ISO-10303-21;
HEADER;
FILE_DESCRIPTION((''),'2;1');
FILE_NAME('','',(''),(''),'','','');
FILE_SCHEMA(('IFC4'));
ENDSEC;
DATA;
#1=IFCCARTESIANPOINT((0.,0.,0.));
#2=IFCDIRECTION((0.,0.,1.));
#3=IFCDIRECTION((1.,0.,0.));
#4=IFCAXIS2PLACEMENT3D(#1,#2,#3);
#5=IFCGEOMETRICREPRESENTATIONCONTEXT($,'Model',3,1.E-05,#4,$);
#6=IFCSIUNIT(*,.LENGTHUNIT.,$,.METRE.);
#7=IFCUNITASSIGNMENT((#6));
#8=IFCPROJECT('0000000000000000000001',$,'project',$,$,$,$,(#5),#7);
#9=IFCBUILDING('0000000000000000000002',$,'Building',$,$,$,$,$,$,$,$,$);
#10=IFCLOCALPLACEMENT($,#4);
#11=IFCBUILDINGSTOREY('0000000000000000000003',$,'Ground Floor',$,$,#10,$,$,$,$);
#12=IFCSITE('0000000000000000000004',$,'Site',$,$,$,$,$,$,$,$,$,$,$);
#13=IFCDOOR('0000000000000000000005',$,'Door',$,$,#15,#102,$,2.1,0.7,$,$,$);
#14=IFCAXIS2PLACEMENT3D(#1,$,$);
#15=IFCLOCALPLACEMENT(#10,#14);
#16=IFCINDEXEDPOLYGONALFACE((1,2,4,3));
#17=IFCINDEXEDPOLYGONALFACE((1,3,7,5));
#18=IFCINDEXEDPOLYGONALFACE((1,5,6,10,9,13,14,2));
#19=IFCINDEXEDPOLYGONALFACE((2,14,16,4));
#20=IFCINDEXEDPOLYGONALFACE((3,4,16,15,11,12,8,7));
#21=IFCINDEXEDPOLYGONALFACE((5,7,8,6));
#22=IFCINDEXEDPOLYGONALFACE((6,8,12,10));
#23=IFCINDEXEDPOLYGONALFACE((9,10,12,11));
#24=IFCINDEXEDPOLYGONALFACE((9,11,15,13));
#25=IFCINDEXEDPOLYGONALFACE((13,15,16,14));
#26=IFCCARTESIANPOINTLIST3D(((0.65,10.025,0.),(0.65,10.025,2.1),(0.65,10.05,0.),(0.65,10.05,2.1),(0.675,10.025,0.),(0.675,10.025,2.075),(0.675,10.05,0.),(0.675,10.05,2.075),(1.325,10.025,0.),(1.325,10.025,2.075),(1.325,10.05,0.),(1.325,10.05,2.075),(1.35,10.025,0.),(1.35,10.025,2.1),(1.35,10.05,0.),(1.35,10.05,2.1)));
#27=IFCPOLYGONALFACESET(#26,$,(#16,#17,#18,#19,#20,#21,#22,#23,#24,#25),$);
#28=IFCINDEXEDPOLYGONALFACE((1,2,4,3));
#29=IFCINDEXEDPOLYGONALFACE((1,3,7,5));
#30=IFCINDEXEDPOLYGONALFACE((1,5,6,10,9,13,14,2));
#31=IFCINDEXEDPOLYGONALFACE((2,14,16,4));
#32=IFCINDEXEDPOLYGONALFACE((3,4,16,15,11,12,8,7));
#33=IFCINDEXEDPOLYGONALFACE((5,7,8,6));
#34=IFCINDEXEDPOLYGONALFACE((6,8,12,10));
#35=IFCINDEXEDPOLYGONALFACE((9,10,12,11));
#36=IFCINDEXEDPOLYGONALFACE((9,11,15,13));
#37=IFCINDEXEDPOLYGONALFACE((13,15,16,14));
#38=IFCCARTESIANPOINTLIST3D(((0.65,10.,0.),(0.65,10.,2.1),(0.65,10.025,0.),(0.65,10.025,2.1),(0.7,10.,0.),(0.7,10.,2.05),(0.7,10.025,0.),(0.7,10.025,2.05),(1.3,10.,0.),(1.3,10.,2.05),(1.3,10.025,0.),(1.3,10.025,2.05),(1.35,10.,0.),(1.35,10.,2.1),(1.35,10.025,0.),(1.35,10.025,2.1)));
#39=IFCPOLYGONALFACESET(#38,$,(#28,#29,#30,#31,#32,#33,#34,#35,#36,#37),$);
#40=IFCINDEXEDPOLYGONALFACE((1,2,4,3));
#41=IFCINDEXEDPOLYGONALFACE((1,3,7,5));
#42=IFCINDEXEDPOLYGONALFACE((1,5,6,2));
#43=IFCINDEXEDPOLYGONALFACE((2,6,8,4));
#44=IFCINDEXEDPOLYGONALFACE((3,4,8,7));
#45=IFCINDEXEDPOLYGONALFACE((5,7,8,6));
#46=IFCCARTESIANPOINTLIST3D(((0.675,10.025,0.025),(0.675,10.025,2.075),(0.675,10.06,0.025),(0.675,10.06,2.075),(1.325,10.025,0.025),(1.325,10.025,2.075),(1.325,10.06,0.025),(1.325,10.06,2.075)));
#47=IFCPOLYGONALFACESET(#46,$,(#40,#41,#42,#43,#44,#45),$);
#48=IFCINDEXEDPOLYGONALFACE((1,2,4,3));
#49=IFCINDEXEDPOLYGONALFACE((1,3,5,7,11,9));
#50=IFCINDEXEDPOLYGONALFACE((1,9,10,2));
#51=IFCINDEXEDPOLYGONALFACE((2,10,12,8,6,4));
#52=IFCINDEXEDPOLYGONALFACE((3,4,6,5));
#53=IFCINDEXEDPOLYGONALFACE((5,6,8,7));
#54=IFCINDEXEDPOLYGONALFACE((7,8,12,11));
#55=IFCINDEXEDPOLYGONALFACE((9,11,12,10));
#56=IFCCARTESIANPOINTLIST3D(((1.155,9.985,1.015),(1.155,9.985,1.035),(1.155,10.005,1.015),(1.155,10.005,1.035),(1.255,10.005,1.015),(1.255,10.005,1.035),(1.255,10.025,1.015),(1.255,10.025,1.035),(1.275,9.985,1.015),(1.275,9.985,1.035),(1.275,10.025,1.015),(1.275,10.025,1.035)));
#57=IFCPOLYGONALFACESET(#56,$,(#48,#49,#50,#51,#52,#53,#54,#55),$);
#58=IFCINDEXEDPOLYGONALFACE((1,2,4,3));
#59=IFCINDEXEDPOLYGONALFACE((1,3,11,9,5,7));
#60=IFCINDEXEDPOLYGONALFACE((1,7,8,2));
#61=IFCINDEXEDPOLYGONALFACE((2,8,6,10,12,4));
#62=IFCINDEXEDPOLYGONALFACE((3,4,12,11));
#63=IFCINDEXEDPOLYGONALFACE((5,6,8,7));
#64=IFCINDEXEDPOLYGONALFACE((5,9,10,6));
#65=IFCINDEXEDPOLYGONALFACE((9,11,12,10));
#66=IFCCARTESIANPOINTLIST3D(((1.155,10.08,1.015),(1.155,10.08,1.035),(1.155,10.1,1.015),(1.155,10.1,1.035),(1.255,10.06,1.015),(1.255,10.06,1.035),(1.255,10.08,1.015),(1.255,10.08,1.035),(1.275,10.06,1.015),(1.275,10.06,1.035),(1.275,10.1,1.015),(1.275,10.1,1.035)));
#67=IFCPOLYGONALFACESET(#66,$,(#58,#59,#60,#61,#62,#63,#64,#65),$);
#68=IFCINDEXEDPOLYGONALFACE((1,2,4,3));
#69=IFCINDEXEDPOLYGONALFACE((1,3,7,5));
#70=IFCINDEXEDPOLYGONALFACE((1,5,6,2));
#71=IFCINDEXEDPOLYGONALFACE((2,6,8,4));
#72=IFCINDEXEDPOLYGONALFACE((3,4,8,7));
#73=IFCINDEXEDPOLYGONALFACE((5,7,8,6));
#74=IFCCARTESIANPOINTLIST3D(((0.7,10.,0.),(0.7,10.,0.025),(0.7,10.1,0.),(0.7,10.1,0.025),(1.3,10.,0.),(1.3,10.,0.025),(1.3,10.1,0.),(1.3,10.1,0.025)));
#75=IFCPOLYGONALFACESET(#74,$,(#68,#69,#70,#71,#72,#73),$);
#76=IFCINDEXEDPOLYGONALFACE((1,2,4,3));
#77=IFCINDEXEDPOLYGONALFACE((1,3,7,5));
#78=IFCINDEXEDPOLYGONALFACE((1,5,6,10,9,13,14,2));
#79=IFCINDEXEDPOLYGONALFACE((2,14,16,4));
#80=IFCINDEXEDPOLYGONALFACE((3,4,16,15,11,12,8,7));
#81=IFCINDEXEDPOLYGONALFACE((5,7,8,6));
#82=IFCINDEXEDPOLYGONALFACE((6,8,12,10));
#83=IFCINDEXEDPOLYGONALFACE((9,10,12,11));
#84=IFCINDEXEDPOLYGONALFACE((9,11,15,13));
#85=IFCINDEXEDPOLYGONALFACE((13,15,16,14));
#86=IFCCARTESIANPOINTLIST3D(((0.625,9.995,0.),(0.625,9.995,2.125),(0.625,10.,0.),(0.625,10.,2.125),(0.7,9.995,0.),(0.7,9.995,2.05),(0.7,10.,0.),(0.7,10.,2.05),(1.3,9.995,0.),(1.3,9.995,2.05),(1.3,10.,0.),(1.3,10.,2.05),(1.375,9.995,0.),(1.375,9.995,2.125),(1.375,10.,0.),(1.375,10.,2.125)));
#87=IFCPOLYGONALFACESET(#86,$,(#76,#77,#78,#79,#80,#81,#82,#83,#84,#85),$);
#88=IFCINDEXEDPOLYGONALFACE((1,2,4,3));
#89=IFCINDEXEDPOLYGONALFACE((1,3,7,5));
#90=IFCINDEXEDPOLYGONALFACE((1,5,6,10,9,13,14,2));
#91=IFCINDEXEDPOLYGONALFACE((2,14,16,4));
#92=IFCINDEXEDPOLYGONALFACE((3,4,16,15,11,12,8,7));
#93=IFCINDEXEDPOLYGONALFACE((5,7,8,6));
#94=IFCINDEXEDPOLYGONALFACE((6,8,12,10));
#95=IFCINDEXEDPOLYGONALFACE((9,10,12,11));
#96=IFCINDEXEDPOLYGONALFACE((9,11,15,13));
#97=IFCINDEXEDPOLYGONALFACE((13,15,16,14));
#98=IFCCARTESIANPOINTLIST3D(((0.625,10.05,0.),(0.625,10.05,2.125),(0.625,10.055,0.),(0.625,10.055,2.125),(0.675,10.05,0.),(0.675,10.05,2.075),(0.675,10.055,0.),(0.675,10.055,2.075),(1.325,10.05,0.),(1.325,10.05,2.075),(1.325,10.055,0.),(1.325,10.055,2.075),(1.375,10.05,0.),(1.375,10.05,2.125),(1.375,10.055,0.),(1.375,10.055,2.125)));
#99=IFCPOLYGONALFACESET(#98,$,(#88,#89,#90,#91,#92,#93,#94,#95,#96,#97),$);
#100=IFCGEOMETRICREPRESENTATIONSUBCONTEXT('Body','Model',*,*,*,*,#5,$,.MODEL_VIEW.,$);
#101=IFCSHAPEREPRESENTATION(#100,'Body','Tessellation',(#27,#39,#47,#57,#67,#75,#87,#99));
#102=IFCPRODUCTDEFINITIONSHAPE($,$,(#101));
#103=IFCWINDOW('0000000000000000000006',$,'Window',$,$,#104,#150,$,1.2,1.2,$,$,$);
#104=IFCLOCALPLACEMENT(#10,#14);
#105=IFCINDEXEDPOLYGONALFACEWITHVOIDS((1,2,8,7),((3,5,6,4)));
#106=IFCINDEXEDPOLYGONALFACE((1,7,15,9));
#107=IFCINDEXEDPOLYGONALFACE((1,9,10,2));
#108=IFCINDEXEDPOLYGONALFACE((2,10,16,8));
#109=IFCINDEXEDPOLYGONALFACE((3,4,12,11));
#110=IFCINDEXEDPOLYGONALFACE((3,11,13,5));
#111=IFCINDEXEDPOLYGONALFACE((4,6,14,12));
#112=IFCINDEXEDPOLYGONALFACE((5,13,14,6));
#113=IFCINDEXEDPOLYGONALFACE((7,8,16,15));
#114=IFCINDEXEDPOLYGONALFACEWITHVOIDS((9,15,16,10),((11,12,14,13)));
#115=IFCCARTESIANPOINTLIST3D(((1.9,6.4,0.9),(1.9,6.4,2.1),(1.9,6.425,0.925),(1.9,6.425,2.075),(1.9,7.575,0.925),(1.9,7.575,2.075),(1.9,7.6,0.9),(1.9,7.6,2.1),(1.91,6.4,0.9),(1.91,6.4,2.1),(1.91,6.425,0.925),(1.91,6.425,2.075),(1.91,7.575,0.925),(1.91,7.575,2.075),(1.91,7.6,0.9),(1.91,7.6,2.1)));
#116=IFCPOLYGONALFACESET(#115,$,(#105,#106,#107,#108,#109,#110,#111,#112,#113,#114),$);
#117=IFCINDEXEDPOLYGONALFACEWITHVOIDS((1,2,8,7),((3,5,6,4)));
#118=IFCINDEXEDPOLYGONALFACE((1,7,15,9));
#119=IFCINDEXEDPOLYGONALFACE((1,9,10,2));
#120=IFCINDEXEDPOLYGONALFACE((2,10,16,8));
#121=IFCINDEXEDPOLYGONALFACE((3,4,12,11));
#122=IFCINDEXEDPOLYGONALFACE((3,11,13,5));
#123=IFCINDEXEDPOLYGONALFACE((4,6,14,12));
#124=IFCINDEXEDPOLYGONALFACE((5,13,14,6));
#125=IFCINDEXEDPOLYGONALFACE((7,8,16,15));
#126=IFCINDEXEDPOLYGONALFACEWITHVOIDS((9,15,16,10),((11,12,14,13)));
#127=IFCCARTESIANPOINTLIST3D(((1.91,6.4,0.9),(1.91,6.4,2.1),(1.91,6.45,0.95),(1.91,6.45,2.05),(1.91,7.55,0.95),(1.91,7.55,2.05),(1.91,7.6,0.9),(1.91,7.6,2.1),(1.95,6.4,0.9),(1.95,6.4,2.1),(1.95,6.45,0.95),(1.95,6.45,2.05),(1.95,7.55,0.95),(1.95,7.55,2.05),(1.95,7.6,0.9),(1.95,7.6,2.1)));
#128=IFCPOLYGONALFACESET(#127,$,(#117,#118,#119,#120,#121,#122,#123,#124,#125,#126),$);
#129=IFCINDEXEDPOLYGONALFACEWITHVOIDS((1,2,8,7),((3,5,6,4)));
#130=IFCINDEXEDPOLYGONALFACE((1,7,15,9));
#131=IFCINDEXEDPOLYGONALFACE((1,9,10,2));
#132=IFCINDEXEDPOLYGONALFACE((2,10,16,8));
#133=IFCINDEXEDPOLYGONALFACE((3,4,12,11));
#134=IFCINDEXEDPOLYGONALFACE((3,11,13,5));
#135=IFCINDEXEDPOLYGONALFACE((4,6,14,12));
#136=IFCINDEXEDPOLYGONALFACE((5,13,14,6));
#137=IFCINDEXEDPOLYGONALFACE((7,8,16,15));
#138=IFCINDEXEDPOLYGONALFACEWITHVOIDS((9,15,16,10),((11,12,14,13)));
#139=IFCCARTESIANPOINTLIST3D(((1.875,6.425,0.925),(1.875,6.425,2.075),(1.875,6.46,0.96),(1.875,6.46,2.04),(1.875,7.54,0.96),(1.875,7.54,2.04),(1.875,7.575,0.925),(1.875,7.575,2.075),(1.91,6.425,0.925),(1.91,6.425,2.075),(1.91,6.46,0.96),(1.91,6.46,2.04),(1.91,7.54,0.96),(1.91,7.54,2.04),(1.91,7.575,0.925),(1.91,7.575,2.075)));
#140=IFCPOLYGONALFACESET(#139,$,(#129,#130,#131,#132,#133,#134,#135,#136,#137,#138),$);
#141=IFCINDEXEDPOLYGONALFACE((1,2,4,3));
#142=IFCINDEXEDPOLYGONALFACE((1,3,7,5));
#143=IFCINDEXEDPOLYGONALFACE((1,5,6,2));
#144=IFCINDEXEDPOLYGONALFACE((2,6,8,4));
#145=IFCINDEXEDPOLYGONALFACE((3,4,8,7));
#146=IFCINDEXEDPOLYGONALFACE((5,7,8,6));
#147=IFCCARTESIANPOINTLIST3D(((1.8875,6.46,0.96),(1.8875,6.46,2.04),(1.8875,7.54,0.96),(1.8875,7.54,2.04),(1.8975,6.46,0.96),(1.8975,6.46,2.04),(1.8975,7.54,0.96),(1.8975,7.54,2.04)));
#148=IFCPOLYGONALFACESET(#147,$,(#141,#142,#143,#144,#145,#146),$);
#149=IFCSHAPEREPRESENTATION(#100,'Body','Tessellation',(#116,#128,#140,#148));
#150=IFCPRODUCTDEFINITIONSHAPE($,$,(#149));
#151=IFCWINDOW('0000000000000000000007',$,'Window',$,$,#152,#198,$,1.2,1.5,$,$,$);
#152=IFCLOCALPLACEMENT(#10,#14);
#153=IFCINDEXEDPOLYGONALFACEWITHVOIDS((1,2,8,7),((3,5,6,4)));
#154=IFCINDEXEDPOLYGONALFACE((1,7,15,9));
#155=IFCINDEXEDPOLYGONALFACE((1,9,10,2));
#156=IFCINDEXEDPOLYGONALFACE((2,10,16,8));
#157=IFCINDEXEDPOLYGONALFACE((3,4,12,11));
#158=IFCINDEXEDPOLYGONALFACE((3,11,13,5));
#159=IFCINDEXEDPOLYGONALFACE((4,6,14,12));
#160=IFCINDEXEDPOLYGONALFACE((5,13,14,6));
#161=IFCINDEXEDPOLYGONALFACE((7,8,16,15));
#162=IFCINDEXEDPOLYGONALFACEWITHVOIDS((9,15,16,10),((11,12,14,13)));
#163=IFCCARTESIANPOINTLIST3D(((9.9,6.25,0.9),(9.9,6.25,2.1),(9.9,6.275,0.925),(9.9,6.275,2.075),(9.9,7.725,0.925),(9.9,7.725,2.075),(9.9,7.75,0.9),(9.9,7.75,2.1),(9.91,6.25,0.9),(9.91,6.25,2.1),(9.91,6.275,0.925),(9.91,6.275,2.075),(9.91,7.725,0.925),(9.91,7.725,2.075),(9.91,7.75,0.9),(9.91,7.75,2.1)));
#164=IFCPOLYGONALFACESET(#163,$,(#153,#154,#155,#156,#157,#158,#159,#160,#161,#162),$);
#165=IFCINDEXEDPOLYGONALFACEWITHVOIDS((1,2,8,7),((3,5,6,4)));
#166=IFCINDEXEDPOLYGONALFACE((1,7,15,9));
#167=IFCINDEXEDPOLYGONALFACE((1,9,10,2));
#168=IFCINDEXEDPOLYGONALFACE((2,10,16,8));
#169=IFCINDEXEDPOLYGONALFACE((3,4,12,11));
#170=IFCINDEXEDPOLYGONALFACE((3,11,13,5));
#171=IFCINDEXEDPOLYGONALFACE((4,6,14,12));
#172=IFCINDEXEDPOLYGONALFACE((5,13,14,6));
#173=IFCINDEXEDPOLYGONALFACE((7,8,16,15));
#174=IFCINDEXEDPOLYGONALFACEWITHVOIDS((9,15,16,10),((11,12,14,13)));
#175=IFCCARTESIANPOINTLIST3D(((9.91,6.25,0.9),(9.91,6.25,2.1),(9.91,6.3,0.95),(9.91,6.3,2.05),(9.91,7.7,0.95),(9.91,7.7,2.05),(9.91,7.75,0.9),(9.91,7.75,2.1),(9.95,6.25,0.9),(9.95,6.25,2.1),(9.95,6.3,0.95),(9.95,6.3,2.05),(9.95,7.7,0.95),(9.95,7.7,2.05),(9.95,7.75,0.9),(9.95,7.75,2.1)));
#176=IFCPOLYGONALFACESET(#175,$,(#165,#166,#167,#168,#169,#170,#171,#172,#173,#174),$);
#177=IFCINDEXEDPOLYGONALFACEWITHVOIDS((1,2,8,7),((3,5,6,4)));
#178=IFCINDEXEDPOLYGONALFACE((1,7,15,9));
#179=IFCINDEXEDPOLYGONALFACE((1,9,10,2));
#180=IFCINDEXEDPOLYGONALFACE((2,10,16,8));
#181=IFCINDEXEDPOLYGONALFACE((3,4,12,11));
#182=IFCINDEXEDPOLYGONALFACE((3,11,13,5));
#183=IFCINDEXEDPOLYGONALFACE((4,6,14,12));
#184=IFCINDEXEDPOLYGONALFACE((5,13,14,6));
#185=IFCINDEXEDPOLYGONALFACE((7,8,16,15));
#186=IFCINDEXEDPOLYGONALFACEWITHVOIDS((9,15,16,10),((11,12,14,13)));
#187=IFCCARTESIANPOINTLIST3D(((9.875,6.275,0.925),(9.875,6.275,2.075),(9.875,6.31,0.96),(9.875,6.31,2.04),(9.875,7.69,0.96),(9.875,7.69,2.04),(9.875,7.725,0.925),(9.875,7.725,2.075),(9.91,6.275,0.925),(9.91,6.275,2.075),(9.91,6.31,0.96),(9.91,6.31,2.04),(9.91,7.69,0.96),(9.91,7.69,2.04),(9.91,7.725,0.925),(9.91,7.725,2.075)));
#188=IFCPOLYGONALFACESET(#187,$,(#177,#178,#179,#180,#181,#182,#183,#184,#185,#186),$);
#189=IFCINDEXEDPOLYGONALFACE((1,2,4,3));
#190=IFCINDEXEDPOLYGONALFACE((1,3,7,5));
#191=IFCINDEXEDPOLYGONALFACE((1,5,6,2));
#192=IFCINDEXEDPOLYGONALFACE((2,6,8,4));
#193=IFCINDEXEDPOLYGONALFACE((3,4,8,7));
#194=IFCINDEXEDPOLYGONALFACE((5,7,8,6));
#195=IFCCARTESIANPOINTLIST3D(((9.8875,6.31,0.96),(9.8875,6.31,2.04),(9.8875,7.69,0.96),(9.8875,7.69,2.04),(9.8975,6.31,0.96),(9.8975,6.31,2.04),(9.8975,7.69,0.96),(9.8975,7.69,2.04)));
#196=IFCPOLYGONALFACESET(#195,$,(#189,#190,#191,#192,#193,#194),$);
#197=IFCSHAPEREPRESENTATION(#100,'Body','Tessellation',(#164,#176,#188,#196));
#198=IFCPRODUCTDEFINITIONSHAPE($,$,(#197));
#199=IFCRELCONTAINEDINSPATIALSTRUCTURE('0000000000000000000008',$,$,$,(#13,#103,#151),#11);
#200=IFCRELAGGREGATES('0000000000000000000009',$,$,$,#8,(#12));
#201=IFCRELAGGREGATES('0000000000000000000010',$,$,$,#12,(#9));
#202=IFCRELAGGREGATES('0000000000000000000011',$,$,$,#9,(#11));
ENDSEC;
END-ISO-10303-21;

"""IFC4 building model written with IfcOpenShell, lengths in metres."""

from ifc_helpers import new_model, si_unit, frame, origin_with_axes, place, context, subcontext, project, spatial, line, indexed_curve, outline, extrude, element, save


model = new_model("IFC4")

# Units and contexts
model_context = context("Model", 3, precision=1e-05, world=origin_with_axes())
body_context = subcontext(model_context, "Body", "Model", "MODEL_VIEW")
ifc_project = project(units=[si_unit("LENGTHUNIT", "METRE")], contexts=[model_context])

# Site, building, storey
site = spatial("IfcSite", under=ifc_project, Name="Site")
building = spatial("IfcBuilding", under=site, Name="Building")
storey_placement = place(None, origin_with_axes())
storey = spatial("IfcBuildingStorey", under=building, at=storey_placement, Name="Ground Floor")

# Door
door_1_placement = place(storey_placement, frame((0.65, 10.0, 0.0), z_axis=(0.0, 0.0, 1.0), x_axis=(1.0, 0.0, 0.0)))
element("IfcDoor", 1, at=door_1_placement, inside=storey, Name="Door", OverallHeight=2.1, OverallWidth=0.7, context=body_context, shape_type="SweptSolid", body=[
    extrude(outline(indexed_curve([(0.0, 0.0), (0.0, 2.1), (0.7, 2.1), (0.7, 0.0), (0.675, 0.0), (0.675, 2.075), (0.025, 2.075), (0.025, 0.0)], segments=[line(1, 2, 3, 4, 5, 6, 7, 8, 1)])), frame((0.0, 0.025, 0.0), z_axis=(0.0, -1.0, 0.0), x_axis=(1.0, 0.0, 0.0)), (0.0, 0.0, -1.0), 0.025),
    extrude(outline(indexed_curve([(0.0, 0.0), (0.0, 2.1), (0.7, 2.1), (0.7, 0.0), (0.65, 0.0), (0.65, 2.05), (0.05, 2.05), (0.05, 0.0)], segments=[line(1, 2, 3, 4, 5, 6, 7, 8, 1)])), frame((0.0, 0.0, 0.0), z_axis=(0.0, -1.0, 0.0), x_axis=(1.0, 0.0, 0.0)), (0.0, 0.0, -1.0), 0.025),
    extrude(outline(indexed_curve([(0.0, 0.0), (0.65, 0.0), (0.65, 0.035), (0.0, 0.035)], segments=[line(1, 2, 3, 4, 1)])), frame((0.025, 0.025, 0.025), z_axis=(0.0, 0.0, 1.0), x_axis=(1.0, 0.0, 0.0)), (0.0, 0.0, 1.0), 2.05),
    extrude(outline(indexed_curve([(0.0, 0.0), (0.0, -0.04), (-0.12, -0.04), (-0.12, -0.02), (-0.02, -0.02), (-0.02, 0.0)], segments=[line(1, 2, 3, 4, 5, 6, 1)])), frame((0.625, 0.025, 1.015), z_axis=(0.0, 0.0, 1.0), x_axis=(1.0, 0.0, 0.0)), (0.0, 0.0, 1.0), 0.02),
    extrude(outline(indexed_curve([(0.0, 0.0), (0.0, 0.04), (-0.12, 0.04), (-0.12, 0.02), (-0.02, 0.02), (-0.02, 0.0)], segments=[line(1, 2, 3, 4, 5, 6, 1)])), frame((0.625, 0.06, 1.015), z_axis=(0.0, 0.0, 1.0), x_axis=(1.0, 0.0, 0.0)), (0.0, 0.0, 1.0), 0.02),
    extrude(outline(indexed_curve([(0.0, 0.0), (0.6, 0.0), (0.6, 0.1), (0.0, 0.1)], segments=[line(1, 2, 3, 4, 1)])), frame((0.05, 0.0, 0.0), z_axis=(0.0, 0.0, 1.0), x_axis=(1.0, 0.0, 0.0)), (0.0, 0.0, 1.0), 0.025),
    extrude(outline(indexed_curve([(0.0, 0.0), (0.0, 2.125), (0.75, 2.125), (0.75, 0.0), (0.675, 0.0), (0.675, 2.05), (0.075, 2.05), (0.075, 0.0)], segments=[line(1, 2, 3, 4, 5, 6, 7, 8, 1)])), frame((-0.025, -0.005, 0.0), z_axis=(0.0, -1.0, 0.0), x_axis=(1.0, 0.0, 0.0)), (0.0, 0.0, -1.0), 0.005),
    extrude(outline(indexed_curve([(0.0, 0.0), (0.0, 2.125), (0.75, 2.125), (0.75, 0.0), (0.7, 0.0), (0.7, 2.075), (0.05, 2.075), (0.05, 0.0)], segments=[line(1, 2, 3, 4, 5, 6, 7, 8, 1)])), frame((-0.025, 0.05, 0.0), z_axis=(0.0, -1.0, 0.0), x_axis=(1.0, 0.0, 0.0)), (0.0, 0.0, -1.0), 0.005),
])

# Windows
window_1_placement = place(storey_placement, frame((2.0, 6.4, 0.9), z_axis=(0.0, 0.0, 1.0), x_axis=(0.0, 1.0, 0.0)))
element("IfcWindow", 2, at=window_1_placement, inside=storey, Name="Window", OverallHeight=1.2, OverallWidth=1.2, context=body_context, shape_type="SweptSolid", body=[
    extrude(outline(indexed_curve([(0.0, 0.0), (1.2, 0.0), (1.2, 1.2), (0.0, 1.2)], segments=[line(1, 2, 3, 4, 1)]), holes=[indexed_curve([(0.025, 0.025), (1.175, 0.025), (1.175, 1.175), (0.025, 1.175)], segments=[line(1, 2, 3, 4, 1)])]), frame((0.0, 0.09, 0.0), z_axis=(0.0, -1.0, 0.0), x_axis=(1.0, 0.0, 0.0)), (0.0, 0.0, -1.0), 0.01),
    extrude(outline(indexed_curve([(0.0, 0.0), (1.2, 0.0), (1.2, 1.2), (0.0, 1.2)], segments=[line(1, 2, 3, 4, 1)]), holes=[indexed_curve([(0.05, 0.05), (1.15, 0.05), (1.15, 1.15), (0.05, 1.15)], segments=[line(1, 2, 3, 4, 1)])]), frame((0.0, 0.05, 0.0), z_axis=(0.0, -1.0, 0.0), x_axis=(1.0, 0.0, 0.0)), (0.0, 0.0, -1.0), 0.04),
    extrude(outline(indexed_curve([(0.0, 0.0), (1.15, 0.0), (1.15, 1.15), (0.0, 1.15)], segments=[line(1, 2, 3, 4, 1)]), holes=[indexed_curve([(0.035, 0.035), (1.115, 0.035), (1.115, 1.115), (0.035, 1.115)], segments=[line(1, 2, 3, 4, 1)])]), frame((0.025, 0.09, 0.025), z_axis=(0.0, -1.0, 0.0), x_axis=(1.0, 0.0, 0.0)), (0.0, 0.0, -1.0), 0.035),
    extrude(outline(indexed_curve([(0.035, 0.035), (1.115, 0.035), (1.115, 1.115), (0.035, 1.115)], segments=[line(1, 2, 3, 4, 1)])), frame((0.025, 0.1025, 0.025), z_axis=(0.0, -1.0, 0.0), x_axis=(1.0, 0.0, 0.0)), (0.0, 0.0, -1.0), 0.01),
])
window_2_placement = place(storey_placement, frame((10.0, 6.25, 0.9), z_axis=(0.0, 0.0, 1.0), x_axis=(0.0, 1.0, 0.0)))
element("IfcWindow", 3, at=window_2_placement, inside=storey, Name="Window", OverallHeight=1.2, OverallWidth=1.5, context=body_context, shape_type="SweptSolid", body=[
    extrude(outline(indexed_curve([(0.0, 0.0), (1.5, 0.0), (1.5, 1.2), (0.0, 1.2)], segments=[line(1, 2, 3, 4, 1)]), holes=[indexed_curve([(0.025, 0.025), (1.475, 0.025), (1.475, 1.175), (0.025, 1.175)], segments=[line(1, 2, 3, 4, 1)])]), frame((0.0, 0.09, 0.0), z_axis=(0.0, -1.0, 0.0), x_axis=(1.0, 0.0, 0.0)), (0.0, 0.0, -1.0), 0.01),
    extrude(outline(indexed_curve([(0.0, 0.0), (1.5, 0.0), (1.5, 1.2), (0.0, 1.2)], segments=[line(1, 2, 3, 4, 1)]), holes=[indexed_curve([(0.05, 0.05), (1.45, 0.05), (1.45, 1.15), (0.05, 1.15)], segments=[line(1, 2, 3, 4, 1)])]), frame((0.0, 0.05, 0.0), z_axis=(0.0, -1.0, 0.0), x_axis=(1.0, 0.0, 0.0)), (0.0, 0.0, -1.0), 0.04),
    extrude(outline(indexed_curve([(0.0, 0.0), (1.45, 0.0), (1.45, 1.15), (0.0, 1.15)], segments=[line(1, 2, 3, 4, 1)]), holes=[indexed_curve([(0.035, 0.035), (1.415, 0.035), (1.415, 1.115), (0.035, 1.115)], segments=[line(1, 2, 3, 4, 1)])]), frame((0.025, 0.09, 0.025), z_axis=(0.0, -1.0, 0.0), x_axis=(1.0, 0.0, 0.0)), (0.0, 0.0, -1.0), 0.035),
    extrude(outline(indexed_curve([(0.035, 0.035), (1.415, 0.035), (1.415, 1.115), (0.035, 1.115)], segments=[line(1, 2, 3, 4, 1)])), frame((0.025, 0.1025, 0.025), z_axis=(0.0, -1.0, 0.0), x_axis=(1.0, 0.0, 0.0)), (0.0, 0.0, -1.0), 0.01),
])

save(model, "model.ifc")
